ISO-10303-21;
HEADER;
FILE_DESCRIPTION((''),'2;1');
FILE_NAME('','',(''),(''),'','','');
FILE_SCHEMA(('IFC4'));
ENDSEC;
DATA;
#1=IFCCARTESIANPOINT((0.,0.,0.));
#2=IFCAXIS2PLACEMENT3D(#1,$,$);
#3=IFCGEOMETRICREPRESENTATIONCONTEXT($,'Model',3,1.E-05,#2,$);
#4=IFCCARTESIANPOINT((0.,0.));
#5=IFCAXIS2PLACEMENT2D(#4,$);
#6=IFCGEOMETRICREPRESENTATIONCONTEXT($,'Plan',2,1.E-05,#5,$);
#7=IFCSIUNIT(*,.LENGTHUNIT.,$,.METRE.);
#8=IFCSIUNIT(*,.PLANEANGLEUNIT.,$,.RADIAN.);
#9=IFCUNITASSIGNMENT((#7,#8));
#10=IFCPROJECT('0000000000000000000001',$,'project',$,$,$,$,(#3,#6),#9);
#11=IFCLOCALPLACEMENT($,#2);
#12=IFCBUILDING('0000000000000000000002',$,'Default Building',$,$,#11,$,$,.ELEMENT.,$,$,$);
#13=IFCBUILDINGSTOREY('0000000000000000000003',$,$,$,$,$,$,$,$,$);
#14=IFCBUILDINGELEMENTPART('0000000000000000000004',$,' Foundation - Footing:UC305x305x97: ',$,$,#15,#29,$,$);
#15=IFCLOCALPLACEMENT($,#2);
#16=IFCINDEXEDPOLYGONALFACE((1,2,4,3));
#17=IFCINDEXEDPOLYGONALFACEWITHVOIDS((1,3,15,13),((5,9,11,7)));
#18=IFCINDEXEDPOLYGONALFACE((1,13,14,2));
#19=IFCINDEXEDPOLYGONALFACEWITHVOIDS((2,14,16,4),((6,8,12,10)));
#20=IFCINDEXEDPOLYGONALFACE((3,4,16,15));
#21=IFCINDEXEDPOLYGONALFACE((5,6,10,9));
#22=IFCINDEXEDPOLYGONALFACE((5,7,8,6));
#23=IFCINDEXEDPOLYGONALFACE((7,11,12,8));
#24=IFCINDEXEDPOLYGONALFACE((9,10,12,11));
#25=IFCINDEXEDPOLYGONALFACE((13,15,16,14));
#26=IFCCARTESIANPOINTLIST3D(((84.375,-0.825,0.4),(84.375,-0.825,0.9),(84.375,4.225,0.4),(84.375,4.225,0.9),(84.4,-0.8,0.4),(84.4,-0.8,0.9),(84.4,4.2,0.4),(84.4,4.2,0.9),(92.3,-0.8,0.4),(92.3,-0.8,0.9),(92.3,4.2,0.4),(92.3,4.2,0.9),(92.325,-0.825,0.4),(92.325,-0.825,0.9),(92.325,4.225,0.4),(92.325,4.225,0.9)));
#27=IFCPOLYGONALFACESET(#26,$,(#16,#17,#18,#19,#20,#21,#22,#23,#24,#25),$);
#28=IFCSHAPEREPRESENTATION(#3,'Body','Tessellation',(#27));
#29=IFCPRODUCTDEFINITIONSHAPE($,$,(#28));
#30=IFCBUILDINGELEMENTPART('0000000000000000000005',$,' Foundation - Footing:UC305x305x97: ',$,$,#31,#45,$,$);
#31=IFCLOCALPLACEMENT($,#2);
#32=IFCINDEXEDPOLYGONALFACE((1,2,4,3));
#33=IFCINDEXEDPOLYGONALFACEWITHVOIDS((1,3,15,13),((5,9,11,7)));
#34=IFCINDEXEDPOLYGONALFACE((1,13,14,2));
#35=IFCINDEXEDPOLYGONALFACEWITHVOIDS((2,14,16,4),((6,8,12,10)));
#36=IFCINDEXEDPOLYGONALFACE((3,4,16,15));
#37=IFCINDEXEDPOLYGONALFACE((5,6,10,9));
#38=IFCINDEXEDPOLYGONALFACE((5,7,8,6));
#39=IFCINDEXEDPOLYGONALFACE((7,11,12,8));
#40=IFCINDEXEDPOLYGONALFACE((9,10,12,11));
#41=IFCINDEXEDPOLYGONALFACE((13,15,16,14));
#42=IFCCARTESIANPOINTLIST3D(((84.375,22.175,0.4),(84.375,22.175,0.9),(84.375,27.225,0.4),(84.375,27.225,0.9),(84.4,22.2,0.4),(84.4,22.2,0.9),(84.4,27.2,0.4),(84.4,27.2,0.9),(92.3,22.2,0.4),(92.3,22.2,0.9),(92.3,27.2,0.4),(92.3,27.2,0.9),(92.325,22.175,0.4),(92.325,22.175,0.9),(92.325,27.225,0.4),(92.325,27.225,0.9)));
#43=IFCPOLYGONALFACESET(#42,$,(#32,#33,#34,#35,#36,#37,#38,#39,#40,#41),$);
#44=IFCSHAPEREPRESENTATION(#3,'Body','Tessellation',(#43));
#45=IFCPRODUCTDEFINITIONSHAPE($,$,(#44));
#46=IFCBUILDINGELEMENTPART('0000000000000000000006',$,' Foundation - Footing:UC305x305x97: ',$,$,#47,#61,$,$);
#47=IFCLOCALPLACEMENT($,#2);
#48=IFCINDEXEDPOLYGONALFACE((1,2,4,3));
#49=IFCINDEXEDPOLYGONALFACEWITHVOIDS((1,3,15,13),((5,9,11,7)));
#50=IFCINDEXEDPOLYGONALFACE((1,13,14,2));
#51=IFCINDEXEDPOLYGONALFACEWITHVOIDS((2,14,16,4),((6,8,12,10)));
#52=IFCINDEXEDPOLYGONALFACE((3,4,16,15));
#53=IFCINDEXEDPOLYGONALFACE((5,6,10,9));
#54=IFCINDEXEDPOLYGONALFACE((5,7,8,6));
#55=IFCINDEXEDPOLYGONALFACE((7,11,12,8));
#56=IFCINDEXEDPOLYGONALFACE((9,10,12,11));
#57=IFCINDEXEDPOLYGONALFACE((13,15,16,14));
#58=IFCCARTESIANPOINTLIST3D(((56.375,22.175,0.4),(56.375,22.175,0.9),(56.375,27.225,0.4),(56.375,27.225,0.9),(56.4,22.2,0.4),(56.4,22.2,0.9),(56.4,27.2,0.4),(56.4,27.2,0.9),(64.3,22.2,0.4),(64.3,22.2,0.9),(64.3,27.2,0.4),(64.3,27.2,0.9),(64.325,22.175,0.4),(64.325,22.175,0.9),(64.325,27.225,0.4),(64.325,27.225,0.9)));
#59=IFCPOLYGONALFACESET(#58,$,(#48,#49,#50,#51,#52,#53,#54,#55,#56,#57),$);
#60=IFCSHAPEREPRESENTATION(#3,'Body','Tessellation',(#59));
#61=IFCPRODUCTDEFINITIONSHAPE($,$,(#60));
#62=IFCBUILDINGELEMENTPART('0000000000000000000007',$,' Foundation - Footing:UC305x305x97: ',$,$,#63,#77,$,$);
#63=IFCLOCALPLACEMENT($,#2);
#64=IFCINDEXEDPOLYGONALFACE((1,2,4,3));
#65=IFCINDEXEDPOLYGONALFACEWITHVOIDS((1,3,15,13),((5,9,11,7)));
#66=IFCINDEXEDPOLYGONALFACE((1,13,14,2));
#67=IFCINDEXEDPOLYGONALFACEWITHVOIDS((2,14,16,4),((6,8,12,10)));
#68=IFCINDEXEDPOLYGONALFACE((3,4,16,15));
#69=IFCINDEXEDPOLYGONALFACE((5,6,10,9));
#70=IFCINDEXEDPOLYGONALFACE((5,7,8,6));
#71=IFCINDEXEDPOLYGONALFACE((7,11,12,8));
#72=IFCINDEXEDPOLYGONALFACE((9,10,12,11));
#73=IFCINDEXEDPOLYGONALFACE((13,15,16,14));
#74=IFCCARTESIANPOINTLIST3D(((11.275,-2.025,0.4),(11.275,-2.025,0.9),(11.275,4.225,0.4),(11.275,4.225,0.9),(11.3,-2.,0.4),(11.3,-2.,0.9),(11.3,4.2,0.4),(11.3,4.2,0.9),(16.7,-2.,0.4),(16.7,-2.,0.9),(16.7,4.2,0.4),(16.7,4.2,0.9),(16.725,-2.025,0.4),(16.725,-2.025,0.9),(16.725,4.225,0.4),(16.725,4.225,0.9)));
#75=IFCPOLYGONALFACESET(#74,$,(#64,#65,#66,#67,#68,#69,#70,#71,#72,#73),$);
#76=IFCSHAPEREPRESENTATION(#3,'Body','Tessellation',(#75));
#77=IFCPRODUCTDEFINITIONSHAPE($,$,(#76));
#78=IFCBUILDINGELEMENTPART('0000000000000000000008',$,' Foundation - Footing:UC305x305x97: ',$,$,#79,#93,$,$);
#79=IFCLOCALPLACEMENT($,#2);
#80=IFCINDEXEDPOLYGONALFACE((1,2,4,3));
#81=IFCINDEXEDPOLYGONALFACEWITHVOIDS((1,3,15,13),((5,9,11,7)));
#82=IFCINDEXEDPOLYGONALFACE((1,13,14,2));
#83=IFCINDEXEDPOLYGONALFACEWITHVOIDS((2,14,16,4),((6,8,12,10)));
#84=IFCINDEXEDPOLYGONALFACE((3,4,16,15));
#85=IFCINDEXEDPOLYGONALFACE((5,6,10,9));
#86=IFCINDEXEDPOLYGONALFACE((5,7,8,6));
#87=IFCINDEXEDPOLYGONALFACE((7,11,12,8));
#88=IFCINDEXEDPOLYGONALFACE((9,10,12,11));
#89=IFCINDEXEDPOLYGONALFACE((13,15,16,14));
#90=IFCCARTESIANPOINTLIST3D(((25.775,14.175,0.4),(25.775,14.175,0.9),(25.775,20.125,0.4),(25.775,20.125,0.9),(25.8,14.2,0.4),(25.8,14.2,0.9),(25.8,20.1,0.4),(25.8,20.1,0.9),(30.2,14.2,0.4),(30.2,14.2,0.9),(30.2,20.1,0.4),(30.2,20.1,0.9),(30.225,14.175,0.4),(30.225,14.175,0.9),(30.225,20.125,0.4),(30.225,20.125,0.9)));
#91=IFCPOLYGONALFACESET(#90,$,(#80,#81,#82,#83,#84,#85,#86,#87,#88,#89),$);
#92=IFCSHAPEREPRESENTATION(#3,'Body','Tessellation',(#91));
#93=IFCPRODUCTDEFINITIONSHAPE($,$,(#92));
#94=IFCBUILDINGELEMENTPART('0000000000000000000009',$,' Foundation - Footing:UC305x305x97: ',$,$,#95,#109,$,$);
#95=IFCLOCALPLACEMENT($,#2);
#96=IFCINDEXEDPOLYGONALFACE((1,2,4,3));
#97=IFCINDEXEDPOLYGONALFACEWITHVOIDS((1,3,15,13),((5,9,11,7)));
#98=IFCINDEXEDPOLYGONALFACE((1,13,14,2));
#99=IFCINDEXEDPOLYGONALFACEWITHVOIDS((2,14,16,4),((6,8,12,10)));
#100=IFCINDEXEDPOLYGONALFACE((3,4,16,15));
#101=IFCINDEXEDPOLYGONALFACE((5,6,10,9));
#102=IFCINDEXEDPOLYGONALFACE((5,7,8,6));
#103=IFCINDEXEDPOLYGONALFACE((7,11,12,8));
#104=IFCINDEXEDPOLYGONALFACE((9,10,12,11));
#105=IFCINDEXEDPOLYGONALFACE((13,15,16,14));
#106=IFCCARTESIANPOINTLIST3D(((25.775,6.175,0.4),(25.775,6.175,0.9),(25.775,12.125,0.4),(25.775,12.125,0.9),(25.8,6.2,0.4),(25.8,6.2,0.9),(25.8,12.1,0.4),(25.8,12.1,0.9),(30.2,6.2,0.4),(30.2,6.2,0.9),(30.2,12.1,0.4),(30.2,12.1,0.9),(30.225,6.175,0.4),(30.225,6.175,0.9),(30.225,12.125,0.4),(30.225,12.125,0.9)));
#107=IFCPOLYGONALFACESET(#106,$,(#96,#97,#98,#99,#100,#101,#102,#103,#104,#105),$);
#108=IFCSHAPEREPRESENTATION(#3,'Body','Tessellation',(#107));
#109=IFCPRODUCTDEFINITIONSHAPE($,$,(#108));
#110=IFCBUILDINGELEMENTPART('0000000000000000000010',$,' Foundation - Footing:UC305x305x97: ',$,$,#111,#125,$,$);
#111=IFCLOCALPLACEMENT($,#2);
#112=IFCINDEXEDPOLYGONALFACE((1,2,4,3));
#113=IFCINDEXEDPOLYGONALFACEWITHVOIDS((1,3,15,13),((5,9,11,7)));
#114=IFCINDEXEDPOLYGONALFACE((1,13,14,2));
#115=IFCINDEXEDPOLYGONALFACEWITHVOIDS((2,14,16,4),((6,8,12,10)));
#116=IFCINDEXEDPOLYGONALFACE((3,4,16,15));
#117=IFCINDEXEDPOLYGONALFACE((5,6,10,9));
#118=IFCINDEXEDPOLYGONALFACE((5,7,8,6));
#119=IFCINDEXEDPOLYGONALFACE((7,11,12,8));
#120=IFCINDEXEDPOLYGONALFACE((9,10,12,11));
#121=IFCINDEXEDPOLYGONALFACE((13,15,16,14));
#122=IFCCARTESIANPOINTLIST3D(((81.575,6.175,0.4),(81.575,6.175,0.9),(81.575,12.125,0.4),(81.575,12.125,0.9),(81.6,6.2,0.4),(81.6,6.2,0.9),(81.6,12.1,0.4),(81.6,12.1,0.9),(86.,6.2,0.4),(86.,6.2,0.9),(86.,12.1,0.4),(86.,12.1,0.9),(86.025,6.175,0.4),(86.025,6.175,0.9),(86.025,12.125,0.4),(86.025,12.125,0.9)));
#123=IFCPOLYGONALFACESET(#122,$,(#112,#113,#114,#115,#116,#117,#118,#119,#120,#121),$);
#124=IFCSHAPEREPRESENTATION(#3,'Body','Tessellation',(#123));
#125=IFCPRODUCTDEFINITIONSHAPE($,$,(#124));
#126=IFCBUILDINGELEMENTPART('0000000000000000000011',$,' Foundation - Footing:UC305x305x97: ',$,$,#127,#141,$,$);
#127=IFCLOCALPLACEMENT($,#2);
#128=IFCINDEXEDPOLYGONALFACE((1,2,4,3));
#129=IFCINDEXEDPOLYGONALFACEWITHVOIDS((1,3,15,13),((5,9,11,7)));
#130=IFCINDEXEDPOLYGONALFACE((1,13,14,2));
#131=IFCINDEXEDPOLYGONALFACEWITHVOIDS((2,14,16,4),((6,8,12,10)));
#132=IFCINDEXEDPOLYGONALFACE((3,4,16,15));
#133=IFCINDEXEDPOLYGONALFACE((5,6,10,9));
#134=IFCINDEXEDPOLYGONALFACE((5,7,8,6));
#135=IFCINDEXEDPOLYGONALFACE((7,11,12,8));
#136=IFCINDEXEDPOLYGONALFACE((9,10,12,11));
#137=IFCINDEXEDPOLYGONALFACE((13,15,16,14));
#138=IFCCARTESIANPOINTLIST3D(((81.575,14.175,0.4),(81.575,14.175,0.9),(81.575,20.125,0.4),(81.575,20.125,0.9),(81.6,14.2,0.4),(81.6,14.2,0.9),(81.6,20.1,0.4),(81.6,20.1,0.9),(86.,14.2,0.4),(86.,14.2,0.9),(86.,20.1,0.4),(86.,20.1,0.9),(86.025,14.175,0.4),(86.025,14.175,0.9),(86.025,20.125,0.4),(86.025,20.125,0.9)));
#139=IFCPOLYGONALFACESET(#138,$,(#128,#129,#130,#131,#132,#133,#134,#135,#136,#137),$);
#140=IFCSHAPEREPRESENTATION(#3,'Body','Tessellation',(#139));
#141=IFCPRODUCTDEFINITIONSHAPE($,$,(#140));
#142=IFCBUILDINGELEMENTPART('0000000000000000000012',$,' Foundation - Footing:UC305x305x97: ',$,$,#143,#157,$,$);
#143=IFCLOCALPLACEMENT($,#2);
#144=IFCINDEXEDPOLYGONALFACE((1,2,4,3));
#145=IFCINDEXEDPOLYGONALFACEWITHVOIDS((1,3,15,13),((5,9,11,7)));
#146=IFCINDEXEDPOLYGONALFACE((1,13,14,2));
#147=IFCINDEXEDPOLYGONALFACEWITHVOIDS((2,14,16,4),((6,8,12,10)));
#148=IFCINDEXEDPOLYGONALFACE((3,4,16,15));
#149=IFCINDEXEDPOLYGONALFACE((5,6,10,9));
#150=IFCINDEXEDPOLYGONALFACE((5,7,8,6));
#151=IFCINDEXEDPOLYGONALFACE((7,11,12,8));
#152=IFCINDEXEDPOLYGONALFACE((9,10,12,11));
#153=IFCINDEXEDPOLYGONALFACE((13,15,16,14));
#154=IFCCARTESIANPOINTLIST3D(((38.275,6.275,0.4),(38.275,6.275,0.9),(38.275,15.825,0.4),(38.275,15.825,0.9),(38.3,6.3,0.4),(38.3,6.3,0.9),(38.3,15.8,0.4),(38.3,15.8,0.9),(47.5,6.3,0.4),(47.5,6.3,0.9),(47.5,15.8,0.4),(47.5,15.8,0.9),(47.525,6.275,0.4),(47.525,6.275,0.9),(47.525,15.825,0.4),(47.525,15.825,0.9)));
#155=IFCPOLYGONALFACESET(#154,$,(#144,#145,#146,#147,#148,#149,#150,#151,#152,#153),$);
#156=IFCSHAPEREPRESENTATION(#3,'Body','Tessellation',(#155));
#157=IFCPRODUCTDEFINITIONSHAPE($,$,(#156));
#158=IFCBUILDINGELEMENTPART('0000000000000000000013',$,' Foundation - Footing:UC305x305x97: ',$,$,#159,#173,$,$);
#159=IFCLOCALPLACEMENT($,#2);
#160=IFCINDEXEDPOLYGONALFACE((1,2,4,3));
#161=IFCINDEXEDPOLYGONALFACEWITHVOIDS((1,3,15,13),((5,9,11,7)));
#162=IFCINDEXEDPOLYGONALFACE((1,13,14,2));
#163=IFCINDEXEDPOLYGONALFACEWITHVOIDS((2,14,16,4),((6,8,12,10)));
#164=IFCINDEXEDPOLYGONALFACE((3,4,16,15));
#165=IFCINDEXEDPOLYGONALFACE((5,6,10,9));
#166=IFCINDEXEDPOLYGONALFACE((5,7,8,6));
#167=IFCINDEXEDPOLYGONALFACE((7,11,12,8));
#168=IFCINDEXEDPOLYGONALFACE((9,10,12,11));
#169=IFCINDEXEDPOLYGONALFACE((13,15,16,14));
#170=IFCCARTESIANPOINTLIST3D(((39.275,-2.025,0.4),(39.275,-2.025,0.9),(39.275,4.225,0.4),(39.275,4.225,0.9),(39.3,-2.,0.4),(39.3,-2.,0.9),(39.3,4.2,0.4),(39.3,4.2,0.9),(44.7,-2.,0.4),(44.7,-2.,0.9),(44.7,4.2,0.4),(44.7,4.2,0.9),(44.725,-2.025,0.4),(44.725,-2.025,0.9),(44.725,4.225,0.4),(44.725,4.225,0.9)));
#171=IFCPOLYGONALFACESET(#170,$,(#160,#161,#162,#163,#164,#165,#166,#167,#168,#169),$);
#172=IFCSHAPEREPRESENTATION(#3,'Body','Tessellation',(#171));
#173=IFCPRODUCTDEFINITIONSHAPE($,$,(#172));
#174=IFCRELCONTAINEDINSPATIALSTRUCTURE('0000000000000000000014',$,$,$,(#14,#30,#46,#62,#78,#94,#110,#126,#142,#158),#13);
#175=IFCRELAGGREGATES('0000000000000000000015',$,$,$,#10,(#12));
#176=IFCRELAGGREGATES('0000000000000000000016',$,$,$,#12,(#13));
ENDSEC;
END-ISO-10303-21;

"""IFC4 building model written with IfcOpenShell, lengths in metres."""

from ifc_helpers import new_model, si_unit, origin, origin_2d, place, context, project, spatial, polyline, outline, extrude, element, save


model = new_model("IFC4")

# Units and contexts
model_context = context("Model", 3, precision=1e-05, world=origin())
plan_context = context("Plan", 2, precision=1e-05, world=origin_2d())
ifc_project = project(units=[si_unit("LENGTHUNIT", "METRE"), si_unit("PLANEANGLEUNIT", "RADIAN")], contexts=[model_context, plan_context])

# Building, storey
building_placement = place(None, origin())
building = spatial("IfcBuilding", under=ifc_project, at=building_placement, Name="Default Building", CompositionType="ELEMENT")
storey = spatial("IfcBuildingStorey", under=building)

# Building element parts, openings
building_element_part_1 = element("IfcBuildingElementPart", 1, inside=storey, Name=" Foundation - Footing:UC305x305x97: ", context=model_context, shape_type="SweptSolid", body=[
    extrude(outline(polyline([(92.325, 4.225, 0.4), (84.375, 4.225, 0.4), (84.375, -0.825, 0.4), (92.325, -0.825, 0.4), (92.325, 4.225, 0.4)])), None, (0.0, 0.0, 1.0), 0.5),
])
element("IfcOpeningElement", 2, inside=storey, cuts=building_element_part_1, context=model_context, shape_type="SweptSolid", body=[
    extrude(outline(polyline([(92.3, 4.2, 0.4), (84.4, 4.2, 0.4), (84.4, -0.8, 0.4), (92.3, -0.8, 0.4), (92.3, 4.2, 0.4)])), None, (0.0, 0.0, 1.0), 0.5),
])
building_element_part_2 = element("IfcBuildingElementPart", 3, inside=storey, Name=" Foundation - Footing:UC305x305x97: ", context=model_context, shape_type="SweptSolid", body=[
    extrude(outline(polyline([(92.325, 27.225, 0.4), (84.375, 27.225, 0.4), (84.375, 22.175, 0.4), (92.325, 22.175, 0.4), (92.325, 27.225, 0.4)])), None, (0.0, 0.0, 1.0), 0.5),
])
element("IfcOpeningElement", 4, inside=storey, cuts=building_element_part_2, context=model_context, shape_type="SweptSolid", body=[
    extrude(outline(polyline([(92.3, 27.2, 0.4), (84.4, 27.2, 0.4), (84.4, 22.2, 0.4), (92.3, 22.2, 0.4), (92.3, 27.2, 0.4)])), None, (0.0, 0.0, 1.0), 0.5),
])
building_element_part_3 = element("IfcBuildingElementPart", 5, inside=storey, Name=" Foundation - Footing:UC305x305x97: ", context=model_context, shape_type="SweptSolid", body=[
    extrude(outline(polyline([(64.325, 27.225, 0.4), (56.375, 27.225, 0.4), (56.375, 22.175, 0.4), (64.325, 22.175, 0.4), (64.325, 27.225, 0.4)])), None, (0.0, 0.0, 1.0), 0.5),
])
element("IfcOpeningElement", 6, inside=storey, cuts=building_element_part_3, context=model_context, shape_type="SweptSolid", body=[
    extrude(outline(polyline([(64.3, 27.2, 0.4), (56.4, 27.2, 0.4), (56.4, 22.2, 0.4), (64.3, 22.2, 0.4), (64.3, 27.2, 0.4)])), None, (0.0, 0.0, 1.0), 0.5),
])
building_element_part_4 = element("IfcBuildingElementPart", 7, inside=storey, Name=" Foundation - Footing:UC305x305x97: ", context=model_context, shape_type="SweptSolid", body=[
    extrude(outline(polyline([(16.725, -2.025, 0.4), (16.725, 4.225, 0.4), (11.275, 4.225, 0.4), (11.275, -2.025, 0.4), (16.725, -2.025, 0.4)])), None, (0.0, 0.0, 1.0), 0.5),
])
element("IfcOpeningElement", 8, inside=storey, cuts=building_element_part_4, context=model_context, shape_type="SweptSolid", body=[
    extrude(outline(polyline([(16.7, -2.0, 0.4), (16.7, 4.2, 0.4), (11.3, 4.2, 0.4), (11.3, -2.0, 0.4), (16.7, -2.0, 0.4)])), None, (0.0, 0.0, 1.0), 0.5),
])
building_element_part_5 = element("IfcBuildingElementPart", 9, inside=storey, Name=" Foundation - Footing:UC305x305x97: ", context=model_context, shape_type="SweptSolid", body=[
    extrude(outline(polyline([(30.225, 20.125, 0.4), (25.775, 20.125, 0.4), (25.775, 14.175, 0.4), (30.225, 14.175, 0.4), (30.225, 20.125, 0.4)])), None, (0.0, 0.0, 1.0), 0.5),
])
element("IfcOpeningElement", 10, inside=storey, cuts=building_element_part_5, context=model_context, shape_type="SweptSolid", body=[
    extrude(outline(polyline([(30.2, 20.1, 0.4), (25.8, 20.1, 0.4), (25.8, 14.2, 0.4), (30.2, 14.2, 0.4), (30.2, 20.1, 0.4)])), None, (0.0, 0.0, 1.0), 0.5),
])
building_element_part_6 = element("IfcBuildingElementPart", 11, inside=storey, Name=" Foundation - Footing:UC305x305x97: ", context=model_context, shape_type="SweptSolid", body=[
    extrude(outline(polyline([(30.225, 12.125, 0.4), (25.775, 12.125, 0.4), (25.775, 6.175, 0.4), (30.225, 6.175, 0.4), (30.225, 12.125, 0.4)])), None, (0.0, 0.0, 1.0), 0.5),
])
element("IfcOpeningElement", 12, inside=storey, cuts=building_element_part_6, context=model_context, shape_type="SweptSolid", body=[
    extrude(outline(polyline([(30.2, 12.1, 0.4), (25.8, 12.1, 0.4), (25.8, 6.2, 0.4), (30.2, 6.2, 0.4), (30.2, 12.1, 0.4)])), None, (0.0, 0.0, 1.0), 0.5),
])
building_element_part_7 = element("IfcBuildingElementPart", 13, inside=storey, Name=" Foundation - Footing:UC305x305x97: ", context=model_context, shape_type="SweptSolid", body=[
    extrude(outline(polyline([(86.025, 12.125, 0.4), (81.575, 12.125, 0.4), (81.575, 6.175, 0.4), (86.025, 6.175, 0.4), (86.025, 12.125, 0.4)])), None, (0.0, 0.0, 1.0), 0.5),
])
element("IfcOpeningElement", 14, inside=storey, cuts=building_element_part_7, context=model_context, shape_type="SweptSolid", body=[
    extrude(outline(polyline([(86.0, 12.1, 0.4), (81.6, 12.1, 0.4), (81.6, 6.2, 0.4), (86.0, 6.2, 0.4), (86.0, 12.1, 0.4)])), None, (0.0, 0.0, 1.0), 0.5),
])
building_element_part_8 = element("IfcBuildingElementPart", 15, inside=storey, Name=" Foundation - Footing:UC305x305x97: ", context=model_context, shape_type="SweptSolid", body=[
    extrude(outline(polyline([(86.025, 20.125, 0.4), (81.575, 20.125, 0.4), (81.575, 14.175, 0.4), (86.025, 14.175, 0.4), (86.025, 20.125, 0.4)])), None, (0.0, 0.0, 1.0), 0.5),
])
element("IfcOpeningElement", 16, inside=storey, cuts=building_element_part_8, context=model_context, shape_type="SweptSolid", body=[
    extrude(outline(polyline([(86.0, 20.1, 0.4), (81.6, 20.1, 0.4), (81.6, 14.2, 0.4), (86.0, 14.2, 0.4), (86.0, 20.1, 0.4)])), None, (0.0, 0.0, 1.0), 0.5),
])
building_element_part_9 = element("IfcBuildingElementPart", 17, inside=storey, Name=" Foundation - Footing:UC305x305x97: ", context=model_context, shape_type="SweptSolid", body=[
    extrude(outline(polyline([(38.275, 15.825, 0.4), (47.525, 15.825, 0.4), (47.525, 6.275, 0.4), (38.275, 6.275, 0.4), (38.275, 15.825, 0.4)])), None, (0.0, 0.0, 1.0), 0.5),
])
element("IfcOpeningElement", 18, inside=storey, cuts=building_element_part_9, context=model_context, shape_type="SweptSolid", body=[
    extrude(outline(polyline([(38.3, 15.8, 0.4), (47.5, 15.8, 0.4), (47.5, 6.3, 0.4), (38.3, 6.3, 0.4), (38.3, 15.8, 0.4)])), None, (0.0, 0.0, 1.0), 0.5),
])
building_element_part_10 = element("IfcBuildingElementPart", 19, inside=storey, Name=" Foundation - Footing:UC305x305x97: ", context=model_context, shape_type="SweptSolid", body=[
    extrude(outline(polyline([(44.725, -2.025, 0.4), (44.725, 4.225, 0.4), (39.275, 4.225, 0.4), (39.275, -2.025, 0.4), (44.725, -2.025, 0.4)])), None, (0.0, 0.0, 1.0), 0.5),
])
element("IfcOpeningElement", 20, inside=storey, cuts=building_element_part_10, context=model_context, shape_type="SweptSolid", body=[
    extrude(outline(polyline([(44.7, -2.0, 0.4), (44.7, 4.2, 0.4), (39.3, 4.2, 0.4), (39.3, -2.0, 0.4), (44.7, -2.0, 0.4)])), None, (0.0, 0.0, 1.0), 0.5),
])

save(model, "model.ifc")
